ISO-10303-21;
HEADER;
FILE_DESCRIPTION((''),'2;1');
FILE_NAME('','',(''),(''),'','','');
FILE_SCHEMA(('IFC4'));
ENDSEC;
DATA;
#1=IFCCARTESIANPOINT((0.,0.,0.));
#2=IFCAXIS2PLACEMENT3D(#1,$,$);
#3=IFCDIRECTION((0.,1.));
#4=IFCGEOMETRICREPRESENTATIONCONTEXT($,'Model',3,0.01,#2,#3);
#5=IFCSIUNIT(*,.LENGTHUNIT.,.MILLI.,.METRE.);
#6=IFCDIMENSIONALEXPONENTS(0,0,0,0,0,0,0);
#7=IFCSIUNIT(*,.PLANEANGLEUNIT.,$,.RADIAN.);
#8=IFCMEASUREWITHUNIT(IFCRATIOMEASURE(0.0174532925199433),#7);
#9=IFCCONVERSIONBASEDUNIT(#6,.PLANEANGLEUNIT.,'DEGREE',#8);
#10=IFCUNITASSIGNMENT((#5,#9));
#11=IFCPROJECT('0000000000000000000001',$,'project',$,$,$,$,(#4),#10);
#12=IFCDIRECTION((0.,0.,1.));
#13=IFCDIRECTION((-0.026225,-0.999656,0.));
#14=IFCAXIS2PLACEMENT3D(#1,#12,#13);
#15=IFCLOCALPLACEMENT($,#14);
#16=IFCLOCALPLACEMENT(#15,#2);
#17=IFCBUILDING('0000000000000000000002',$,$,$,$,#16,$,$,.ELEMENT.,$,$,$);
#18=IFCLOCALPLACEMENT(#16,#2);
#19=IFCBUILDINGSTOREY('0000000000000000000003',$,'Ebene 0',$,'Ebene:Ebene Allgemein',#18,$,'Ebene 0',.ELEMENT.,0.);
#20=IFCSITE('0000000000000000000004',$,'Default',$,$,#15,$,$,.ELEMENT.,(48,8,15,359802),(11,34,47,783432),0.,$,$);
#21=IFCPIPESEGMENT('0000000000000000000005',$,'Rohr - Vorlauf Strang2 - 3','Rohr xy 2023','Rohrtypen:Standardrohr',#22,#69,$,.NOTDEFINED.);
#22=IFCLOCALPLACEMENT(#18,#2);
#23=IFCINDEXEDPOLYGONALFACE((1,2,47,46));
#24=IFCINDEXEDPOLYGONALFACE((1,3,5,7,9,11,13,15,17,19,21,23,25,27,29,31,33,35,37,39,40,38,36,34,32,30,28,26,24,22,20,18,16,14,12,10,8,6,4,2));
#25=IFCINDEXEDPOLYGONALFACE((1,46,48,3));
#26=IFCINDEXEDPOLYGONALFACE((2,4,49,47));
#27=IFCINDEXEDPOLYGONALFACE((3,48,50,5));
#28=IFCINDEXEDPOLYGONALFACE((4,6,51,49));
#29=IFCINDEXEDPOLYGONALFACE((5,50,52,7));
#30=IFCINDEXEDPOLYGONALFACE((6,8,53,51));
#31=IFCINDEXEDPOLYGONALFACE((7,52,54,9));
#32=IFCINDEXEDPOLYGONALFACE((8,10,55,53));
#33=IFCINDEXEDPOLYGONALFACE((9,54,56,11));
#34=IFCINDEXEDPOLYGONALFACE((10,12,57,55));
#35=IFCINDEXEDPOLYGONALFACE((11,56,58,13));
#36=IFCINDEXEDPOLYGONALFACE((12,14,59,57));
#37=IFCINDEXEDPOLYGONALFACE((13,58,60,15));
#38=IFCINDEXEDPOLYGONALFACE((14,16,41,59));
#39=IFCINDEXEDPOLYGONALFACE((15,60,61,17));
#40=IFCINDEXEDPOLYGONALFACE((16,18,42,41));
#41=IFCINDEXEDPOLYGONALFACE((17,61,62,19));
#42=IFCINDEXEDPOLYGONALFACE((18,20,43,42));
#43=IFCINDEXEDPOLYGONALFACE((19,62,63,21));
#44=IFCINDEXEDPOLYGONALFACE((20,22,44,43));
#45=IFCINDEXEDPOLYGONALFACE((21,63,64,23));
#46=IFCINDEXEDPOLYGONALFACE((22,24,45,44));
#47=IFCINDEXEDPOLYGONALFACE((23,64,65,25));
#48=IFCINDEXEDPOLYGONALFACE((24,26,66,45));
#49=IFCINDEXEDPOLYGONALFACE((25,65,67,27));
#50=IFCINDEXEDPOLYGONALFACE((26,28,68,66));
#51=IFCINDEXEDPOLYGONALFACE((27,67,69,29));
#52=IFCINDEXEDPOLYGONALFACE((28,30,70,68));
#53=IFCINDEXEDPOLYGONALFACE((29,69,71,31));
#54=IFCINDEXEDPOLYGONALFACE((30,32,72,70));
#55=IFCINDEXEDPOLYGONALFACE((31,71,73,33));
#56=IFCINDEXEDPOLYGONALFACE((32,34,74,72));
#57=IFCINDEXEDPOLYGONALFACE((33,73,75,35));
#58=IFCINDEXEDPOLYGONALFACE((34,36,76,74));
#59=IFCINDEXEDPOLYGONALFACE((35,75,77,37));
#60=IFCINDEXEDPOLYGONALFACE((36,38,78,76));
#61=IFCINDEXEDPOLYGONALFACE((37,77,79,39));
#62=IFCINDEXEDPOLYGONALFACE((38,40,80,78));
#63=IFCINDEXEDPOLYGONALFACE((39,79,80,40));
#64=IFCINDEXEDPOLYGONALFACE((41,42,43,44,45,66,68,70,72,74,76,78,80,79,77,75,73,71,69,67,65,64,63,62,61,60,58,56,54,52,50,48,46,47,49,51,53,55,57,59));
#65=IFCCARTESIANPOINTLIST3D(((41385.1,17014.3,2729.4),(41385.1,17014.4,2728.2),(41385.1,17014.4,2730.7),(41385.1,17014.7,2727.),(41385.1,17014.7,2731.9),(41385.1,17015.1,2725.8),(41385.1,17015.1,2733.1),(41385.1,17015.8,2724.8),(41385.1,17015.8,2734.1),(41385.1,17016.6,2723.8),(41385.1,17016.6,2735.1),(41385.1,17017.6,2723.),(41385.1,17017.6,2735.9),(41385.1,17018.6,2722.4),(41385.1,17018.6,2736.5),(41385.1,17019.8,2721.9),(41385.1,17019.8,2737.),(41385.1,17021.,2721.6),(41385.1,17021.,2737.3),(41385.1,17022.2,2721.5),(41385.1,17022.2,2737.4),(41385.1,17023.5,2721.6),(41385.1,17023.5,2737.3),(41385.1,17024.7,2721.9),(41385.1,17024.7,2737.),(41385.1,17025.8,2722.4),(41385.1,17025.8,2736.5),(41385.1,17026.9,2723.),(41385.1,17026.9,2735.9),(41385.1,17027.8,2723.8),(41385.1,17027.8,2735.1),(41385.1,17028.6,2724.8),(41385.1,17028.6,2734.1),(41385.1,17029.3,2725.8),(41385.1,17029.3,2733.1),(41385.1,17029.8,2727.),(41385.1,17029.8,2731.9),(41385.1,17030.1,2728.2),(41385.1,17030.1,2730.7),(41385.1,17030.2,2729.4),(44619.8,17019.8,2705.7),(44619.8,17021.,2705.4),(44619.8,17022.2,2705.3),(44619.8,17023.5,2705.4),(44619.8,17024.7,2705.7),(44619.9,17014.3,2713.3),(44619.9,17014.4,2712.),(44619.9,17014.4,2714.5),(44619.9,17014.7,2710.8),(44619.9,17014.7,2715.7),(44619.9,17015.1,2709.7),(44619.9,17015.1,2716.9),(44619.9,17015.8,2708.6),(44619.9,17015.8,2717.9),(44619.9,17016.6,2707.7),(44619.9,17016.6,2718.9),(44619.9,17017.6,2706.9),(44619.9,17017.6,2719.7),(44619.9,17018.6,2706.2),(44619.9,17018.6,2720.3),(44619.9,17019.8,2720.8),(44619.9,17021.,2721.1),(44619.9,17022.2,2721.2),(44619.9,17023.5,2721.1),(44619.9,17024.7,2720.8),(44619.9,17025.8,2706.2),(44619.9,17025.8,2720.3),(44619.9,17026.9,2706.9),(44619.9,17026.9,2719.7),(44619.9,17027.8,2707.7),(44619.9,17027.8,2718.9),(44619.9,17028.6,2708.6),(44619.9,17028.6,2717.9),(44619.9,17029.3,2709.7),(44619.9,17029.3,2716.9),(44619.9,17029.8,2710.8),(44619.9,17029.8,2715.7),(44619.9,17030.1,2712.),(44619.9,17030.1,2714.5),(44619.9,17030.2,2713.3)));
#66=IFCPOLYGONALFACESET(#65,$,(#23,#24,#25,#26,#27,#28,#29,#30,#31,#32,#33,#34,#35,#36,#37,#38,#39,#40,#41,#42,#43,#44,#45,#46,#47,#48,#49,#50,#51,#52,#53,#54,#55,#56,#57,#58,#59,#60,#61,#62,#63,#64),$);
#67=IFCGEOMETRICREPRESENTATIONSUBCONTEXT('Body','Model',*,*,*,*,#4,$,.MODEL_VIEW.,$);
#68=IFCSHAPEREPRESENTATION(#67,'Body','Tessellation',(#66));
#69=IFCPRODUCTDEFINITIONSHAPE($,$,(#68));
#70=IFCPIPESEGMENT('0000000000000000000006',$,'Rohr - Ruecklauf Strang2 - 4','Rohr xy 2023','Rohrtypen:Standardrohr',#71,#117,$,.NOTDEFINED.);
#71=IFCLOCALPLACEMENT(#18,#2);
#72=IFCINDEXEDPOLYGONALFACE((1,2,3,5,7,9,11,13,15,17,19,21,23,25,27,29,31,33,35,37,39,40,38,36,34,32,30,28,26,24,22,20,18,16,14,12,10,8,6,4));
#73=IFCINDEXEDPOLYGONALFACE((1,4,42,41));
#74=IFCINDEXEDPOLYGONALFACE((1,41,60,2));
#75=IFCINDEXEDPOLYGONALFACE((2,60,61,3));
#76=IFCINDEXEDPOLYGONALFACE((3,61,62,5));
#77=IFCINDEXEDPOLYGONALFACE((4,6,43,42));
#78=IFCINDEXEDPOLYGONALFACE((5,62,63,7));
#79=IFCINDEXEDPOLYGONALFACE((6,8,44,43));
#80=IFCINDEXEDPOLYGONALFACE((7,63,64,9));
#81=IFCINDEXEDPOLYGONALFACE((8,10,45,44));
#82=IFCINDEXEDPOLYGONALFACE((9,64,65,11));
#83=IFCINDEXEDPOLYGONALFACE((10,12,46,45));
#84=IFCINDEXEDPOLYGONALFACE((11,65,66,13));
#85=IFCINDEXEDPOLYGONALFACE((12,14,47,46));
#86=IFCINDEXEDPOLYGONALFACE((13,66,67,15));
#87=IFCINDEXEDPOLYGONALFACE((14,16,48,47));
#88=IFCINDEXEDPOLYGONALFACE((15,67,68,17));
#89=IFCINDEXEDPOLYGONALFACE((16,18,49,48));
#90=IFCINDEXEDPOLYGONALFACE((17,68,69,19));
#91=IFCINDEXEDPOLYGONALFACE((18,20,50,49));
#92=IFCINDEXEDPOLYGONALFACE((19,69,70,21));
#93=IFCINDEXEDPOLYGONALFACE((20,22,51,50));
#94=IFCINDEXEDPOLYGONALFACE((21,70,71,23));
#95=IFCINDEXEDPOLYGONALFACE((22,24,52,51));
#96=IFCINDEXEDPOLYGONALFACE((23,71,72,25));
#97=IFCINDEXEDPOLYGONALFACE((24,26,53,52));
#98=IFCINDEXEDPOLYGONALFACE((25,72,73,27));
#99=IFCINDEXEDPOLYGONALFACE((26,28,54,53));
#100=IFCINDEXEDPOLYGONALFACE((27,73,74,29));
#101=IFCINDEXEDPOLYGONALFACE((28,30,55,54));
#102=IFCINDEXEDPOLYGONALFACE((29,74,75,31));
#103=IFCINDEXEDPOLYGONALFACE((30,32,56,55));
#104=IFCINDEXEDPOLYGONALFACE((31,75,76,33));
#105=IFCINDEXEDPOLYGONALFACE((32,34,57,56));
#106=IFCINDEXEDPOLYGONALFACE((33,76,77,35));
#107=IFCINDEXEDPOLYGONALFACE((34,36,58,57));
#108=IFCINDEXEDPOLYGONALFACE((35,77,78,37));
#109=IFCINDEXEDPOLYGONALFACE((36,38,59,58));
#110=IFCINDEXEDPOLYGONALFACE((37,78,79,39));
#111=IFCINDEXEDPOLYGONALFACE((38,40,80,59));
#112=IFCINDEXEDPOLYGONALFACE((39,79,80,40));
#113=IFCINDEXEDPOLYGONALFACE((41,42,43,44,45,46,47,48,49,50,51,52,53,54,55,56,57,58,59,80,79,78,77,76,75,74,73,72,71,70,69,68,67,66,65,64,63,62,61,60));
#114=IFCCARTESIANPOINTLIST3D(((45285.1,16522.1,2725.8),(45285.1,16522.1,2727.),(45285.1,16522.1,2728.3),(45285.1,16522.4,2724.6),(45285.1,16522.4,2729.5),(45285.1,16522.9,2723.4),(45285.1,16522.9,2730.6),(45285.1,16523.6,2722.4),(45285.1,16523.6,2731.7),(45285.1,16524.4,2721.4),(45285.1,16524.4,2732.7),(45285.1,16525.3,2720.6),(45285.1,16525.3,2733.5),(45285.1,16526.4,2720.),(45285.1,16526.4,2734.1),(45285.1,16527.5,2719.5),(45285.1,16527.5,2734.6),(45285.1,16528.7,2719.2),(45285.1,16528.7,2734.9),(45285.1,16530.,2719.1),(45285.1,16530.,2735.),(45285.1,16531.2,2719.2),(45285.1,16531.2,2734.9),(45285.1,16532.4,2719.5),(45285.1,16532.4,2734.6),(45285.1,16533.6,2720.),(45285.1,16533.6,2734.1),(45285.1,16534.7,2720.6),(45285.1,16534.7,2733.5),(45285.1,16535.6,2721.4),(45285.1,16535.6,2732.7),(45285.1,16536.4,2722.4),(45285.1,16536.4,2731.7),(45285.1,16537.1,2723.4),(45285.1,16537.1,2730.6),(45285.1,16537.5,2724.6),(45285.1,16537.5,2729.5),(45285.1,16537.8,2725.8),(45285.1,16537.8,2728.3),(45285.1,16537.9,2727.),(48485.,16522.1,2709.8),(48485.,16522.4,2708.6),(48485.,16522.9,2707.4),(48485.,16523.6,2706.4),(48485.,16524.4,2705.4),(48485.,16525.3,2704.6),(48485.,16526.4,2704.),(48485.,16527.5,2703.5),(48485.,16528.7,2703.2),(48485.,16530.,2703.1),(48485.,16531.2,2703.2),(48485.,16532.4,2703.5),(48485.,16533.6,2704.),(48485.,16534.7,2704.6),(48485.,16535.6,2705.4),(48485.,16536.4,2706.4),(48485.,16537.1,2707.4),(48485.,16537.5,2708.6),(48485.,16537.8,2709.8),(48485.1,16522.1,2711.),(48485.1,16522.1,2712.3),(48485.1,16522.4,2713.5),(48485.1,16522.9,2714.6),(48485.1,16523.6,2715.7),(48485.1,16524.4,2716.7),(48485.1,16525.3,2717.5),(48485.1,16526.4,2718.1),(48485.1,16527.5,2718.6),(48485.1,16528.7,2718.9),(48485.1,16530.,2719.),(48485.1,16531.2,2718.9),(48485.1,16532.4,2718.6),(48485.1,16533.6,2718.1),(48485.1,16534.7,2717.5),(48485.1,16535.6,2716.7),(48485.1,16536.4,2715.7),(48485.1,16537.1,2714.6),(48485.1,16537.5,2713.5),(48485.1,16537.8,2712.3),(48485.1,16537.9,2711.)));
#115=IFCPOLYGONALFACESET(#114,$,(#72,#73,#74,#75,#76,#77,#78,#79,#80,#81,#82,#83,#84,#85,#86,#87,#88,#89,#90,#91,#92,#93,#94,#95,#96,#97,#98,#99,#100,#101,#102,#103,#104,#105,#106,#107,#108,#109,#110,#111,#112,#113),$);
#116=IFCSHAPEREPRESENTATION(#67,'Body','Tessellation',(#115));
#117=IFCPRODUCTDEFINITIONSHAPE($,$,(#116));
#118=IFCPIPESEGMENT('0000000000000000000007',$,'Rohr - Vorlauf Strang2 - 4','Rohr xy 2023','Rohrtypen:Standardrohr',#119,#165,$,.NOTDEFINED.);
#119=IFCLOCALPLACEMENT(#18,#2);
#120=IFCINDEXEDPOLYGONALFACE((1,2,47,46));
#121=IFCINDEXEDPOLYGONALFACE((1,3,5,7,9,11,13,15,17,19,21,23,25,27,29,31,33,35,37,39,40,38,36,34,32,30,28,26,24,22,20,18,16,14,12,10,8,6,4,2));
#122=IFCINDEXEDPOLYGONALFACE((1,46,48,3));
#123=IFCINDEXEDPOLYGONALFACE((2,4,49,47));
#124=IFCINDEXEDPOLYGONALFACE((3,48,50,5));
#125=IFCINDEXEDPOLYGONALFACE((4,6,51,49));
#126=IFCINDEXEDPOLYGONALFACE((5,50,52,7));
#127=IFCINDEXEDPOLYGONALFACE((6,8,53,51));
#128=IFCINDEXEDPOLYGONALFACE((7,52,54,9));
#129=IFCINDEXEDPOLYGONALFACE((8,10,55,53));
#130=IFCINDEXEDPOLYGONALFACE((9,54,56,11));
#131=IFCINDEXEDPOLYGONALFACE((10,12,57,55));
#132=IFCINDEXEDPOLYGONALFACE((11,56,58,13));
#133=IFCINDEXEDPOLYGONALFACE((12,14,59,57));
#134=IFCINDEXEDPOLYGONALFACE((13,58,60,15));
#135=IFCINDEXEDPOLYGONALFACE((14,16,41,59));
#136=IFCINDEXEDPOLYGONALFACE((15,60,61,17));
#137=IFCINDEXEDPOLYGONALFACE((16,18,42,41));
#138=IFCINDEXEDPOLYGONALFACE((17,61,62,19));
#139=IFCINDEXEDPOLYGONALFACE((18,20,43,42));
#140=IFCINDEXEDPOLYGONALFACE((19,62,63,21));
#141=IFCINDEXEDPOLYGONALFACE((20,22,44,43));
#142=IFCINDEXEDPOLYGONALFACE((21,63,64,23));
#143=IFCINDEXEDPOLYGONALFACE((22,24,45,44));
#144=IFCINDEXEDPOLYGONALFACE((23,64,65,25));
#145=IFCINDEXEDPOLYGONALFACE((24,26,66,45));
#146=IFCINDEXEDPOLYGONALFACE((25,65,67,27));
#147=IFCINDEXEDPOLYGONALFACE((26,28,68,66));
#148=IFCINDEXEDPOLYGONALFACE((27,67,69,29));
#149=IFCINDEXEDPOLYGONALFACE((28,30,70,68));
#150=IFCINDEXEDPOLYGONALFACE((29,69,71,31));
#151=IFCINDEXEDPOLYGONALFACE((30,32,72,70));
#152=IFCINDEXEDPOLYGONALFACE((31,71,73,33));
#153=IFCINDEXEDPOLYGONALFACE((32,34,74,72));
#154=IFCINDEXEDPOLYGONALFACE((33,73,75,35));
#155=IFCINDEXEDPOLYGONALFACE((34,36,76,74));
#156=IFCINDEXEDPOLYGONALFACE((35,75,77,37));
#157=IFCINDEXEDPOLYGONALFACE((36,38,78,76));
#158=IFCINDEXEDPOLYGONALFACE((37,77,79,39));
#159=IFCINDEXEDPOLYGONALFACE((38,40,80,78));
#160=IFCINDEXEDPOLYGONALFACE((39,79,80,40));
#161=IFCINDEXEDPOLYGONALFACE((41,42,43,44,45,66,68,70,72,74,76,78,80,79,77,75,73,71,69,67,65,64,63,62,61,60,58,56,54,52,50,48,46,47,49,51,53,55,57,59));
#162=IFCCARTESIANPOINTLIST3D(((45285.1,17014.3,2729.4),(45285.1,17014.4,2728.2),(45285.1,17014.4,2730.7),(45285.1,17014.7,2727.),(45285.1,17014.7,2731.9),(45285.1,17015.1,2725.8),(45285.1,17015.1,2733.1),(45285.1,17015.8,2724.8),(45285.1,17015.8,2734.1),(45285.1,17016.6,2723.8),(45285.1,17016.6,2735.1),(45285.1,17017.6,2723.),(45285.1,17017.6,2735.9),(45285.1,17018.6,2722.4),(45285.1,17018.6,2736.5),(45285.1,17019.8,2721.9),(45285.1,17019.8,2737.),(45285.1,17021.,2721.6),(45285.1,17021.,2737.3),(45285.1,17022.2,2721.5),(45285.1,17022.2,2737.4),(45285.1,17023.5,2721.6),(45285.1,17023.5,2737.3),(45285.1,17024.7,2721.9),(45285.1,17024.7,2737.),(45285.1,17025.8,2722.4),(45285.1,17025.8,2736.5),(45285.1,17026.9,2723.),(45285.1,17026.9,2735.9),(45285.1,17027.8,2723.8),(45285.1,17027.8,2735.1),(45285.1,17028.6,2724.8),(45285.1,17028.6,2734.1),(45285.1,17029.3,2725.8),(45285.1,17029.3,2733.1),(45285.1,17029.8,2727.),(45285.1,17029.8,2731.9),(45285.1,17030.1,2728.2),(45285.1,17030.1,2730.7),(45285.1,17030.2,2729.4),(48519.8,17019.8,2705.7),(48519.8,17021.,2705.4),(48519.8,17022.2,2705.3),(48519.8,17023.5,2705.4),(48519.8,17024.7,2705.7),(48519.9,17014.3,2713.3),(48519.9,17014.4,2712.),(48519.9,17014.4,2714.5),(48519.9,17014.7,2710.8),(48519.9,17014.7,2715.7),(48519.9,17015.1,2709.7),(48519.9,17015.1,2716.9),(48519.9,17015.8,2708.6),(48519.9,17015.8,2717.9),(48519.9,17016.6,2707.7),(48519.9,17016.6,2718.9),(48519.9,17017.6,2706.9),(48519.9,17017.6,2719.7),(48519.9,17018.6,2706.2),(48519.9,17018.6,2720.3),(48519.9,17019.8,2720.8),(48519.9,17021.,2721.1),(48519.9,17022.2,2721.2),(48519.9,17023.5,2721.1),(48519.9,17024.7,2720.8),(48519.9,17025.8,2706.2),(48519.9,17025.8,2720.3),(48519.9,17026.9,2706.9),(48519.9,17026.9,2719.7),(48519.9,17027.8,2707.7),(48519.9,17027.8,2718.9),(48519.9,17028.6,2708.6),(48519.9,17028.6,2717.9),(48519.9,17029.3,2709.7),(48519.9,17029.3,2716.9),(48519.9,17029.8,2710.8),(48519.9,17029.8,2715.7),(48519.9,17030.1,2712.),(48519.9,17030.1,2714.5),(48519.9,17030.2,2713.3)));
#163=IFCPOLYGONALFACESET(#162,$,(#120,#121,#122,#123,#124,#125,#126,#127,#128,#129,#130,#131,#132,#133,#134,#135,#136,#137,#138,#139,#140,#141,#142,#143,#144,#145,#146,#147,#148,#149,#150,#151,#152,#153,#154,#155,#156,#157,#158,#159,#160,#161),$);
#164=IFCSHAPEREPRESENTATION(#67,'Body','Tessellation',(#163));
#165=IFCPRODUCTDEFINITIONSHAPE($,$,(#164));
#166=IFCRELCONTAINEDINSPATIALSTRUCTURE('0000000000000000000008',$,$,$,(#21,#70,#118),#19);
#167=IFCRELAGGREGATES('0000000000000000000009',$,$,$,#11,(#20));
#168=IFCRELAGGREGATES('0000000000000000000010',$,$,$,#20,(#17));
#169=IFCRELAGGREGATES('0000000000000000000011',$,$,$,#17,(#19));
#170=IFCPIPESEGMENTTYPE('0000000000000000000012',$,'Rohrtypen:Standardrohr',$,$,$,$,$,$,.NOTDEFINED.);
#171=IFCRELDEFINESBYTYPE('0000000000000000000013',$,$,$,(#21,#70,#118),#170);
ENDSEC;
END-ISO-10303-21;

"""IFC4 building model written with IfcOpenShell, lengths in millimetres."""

from ifc_helpers import new_model, entity, si_unit, converted_unit, direction, frame, origin, place, context, subcontext, project, spatial, indexed_curve, outline, extrude, type_object, element, save


model = new_model("IFC4")

# Units and contexts
model_context = context("Model", 3, precision=0.01, world=origin(), true_north=direction((0.0, 1.0)))
body_context = subcontext(model_context, "Body", "Model", "MODEL_VIEW")
ifc_project = project(units=[si_unit("LENGTHUNIT", "METRE", prefix="MILLI"), converted_unit("PLANEANGLEUNIT", "DEGREE", entity("IfcRatioMeasure", 0.0174532925199433), si_unit("PLANEANGLEUNIT", "RADIAN"), dimensions=[0, 0, 0, 0, 0, 0, 0])], contexts=[model_context])

# Site, building, storey
site_placement = place(None, frame((0.0, 0.0, 0.0), z_axis=(0.0, 0.0, 1.0), x_axis=(-0.026225, -0.999656, 0.0)))
site = spatial("IfcSite", under=ifc_project, at=site_placement, Name="Default", CompositionType="ELEMENT", RefLatitude=(48, 8, 15, 359802), RefLongitude=(11, 34, 47, 783432), RefElevation=0.0)
building_placement = place(site_placement, origin())
building = spatial("IfcBuilding", under=site, at=building_placement, CompositionType="ELEMENT")
storey_placement = place(building_placement, origin())
storey = spatial("IfcBuildingStorey", under=building, at=storey_placement, Name="Ebene 0", ObjectType="Ebene:Ebene Allgemein", LongName="Ebene 0", CompositionType="ELEMENT", Elevation=0.0)

# Pipe segments
pipe_segment_type = type_object("IfcPipeSegmentType", Name="Rohrtypen:Standardrohr", PredefinedType="NOTDEFINED")
pipe_segment_1_placement = place(storey_placement, origin())
element("IfcPipeSegment", 1, at=pipe_segment_1_placement, inside=storey, type_object=pipe_segment_type, Name="Rohr - Vorlauf Strang2 - 3", Description="Rohr xy 2023", ObjectType="Rohrtypen:Standardrohr", PredefinedType="NOTDEFINED", context=body_context, shape_type="SweptSolid", body=[
    extrude(outline(indexed_curve([(7.9, 0.0), (7.8, 1.2), (7.6, 2.5), (7.1, 3.6), (6.4, 4.7), (5.6, 5.6), (4.7, 6.4), (3.6, 7.1), (2.5, 7.6), (1.2, 7.8), (0.0, 7.9), (-1.2, 7.8), (-2.5, 7.6), (-3.6, 7.1), (-4.7, 6.4), (-5.6, 5.6), (-6.4, 4.7), (-7.1, 3.6), (-7.6, 2.5), (-7.8, 1.2), (-7.9, 0.0), (-7.8, -1.2), (-7.6, -2.5), (-7.1, -3.6), (-6.4, -4.7), (-5.6, -5.6), (-4.7, -6.4), (-3.6, -7.1), (-2.5, -7.6), (-1.2, -7.8), (0.0, -7.9), (1.2, -7.8), (2.5, -7.6), (3.6, -7.1), (4.7, -6.4), (5.6, -5.6), (6.4, -4.7), (7.1, -3.6), (7.6, -2.5), (7.8, -1.2), (7.9, 0.0)], self_intersect=False)), frame((44619.9, 17022.2, 2713.3), z_axis=(-0.999988, 0.0, 0.005), x_axis=(0.0, 1.0, 0.0)), (0.0, 0.0, 1.0), 3234.8),
])
pipe_segment_2_placement = place(storey_placement, origin())
element("IfcPipeSegment", 2, at=pipe_segment_2_placement, inside=storey, type_object=pipe_segment_type, Name="Rohr - Ruecklauf Strang2 - 4", Description="Rohr xy 2023", ObjectType="Rohrtypen:Standardrohr", PredefinedType="NOTDEFINED", context=body_context, shape_type="SweptSolid", body=[
    extrude(outline(indexed_curve([(7.9, 0.0), (7.8, 1.2), (7.6, 2.5), (7.1, 3.6), (6.4, 4.7), (5.6, 5.6), (4.7, 6.4), (3.6, 7.1), (2.5, 7.6), (1.2, 7.8), (0.0, 7.9), (-1.2, 7.8), (-2.5, 7.6), (-3.6, 7.1), (-4.7, 6.4), (-5.6, 5.6), (-6.4, 4.7), (-7.1, 3.6), (-7.6, 2.5), (-7.8, 1.2), (-7.9, 0.0), (-7.8, -1.2), (-7.6, -2.5), (-7.1, -3.6), (-6.4, -4.7), (-5.6, -5.6), (-4.7, -6.4), (-3.6, -7.1), (-2.5, -7.6), (-1.2, -7.8), (0.0, -7.9), (1.2, -7.8), (2.5, -7.6), (3.6, -7.1), (4.7, -6.4), (5.6, -5.6), (6.4, -4.7), (7.1, -3.6), (7.6, -2.5), (7.8, -1.2), (7.9, 0.0)], self_intersect=False)), frame((48485.1, 16530.0, 2711.0), z_axis=(-0.999988, 0.0, 0.005), x_axis=(0.0, 1.0, 0.0)), (0.0, 0.0, 1.0), 3200.0),
])
pipe_segment_3_placement = place(storey_placement, origin())
element("IfcPipeSegment", 3, at=pipe_segment_3_placement, inside=storey, type_object=pipe_segment_type, Name="Rohr - Vorlauf Strang2 - 4", Description="Rohr xy 2023", ObjectType="Rohrtypen:Standardrohr", PredefinedType="NOTDEFINED", context=body_context, shape_type="SweptSolid", body=[
    extrude(outline(indexed_curve([(7.9, 0.0), (7.8, 1.2), (7.6, 2.5), (7.1, 3.6), (6.4, 4.7), (5.6, 5.6), (4.7, 6.4), (3.6, 7.1), (2.5, 7.6), (1.2, 7.8), (0.0, 7.9), (-1.2, 7.8), (-2.5, 7.6), (-3.6, 7.1), (-4.7, 6.4), (-5.6, 5.6), (-6.4, 4.7), (-7.1, 3.6), (-7.6, 2.5), (-7.8, 1.2), (-7.9, 0.0), (-7.8, -1.2), (-7.6, -2.5), (-7.1, -3.6), (-6.4, -4.7), (-5.6, -5.6), (-4.7, -6.4), (-3.6, -7.1), (-2.5, -7.6), (-1.2, -7.8), (0.0, -7.9), (1.2, -7.8), (2.5, -7.6), (3.6, -7.1), (4.7, -6.4), (5.6, -5.6), (6.4, -4.7), (7.1, -3.6), (7.6, -2.5), (7.8, -1.2), (7.9, 0.0)], self_intersect=False)), frame((48519.9, 17022.2, 2713.3), z_axis=(-0.999988, 0.0, 0.005), x_axis=(0.0, 1.0, 0.0)), (0.0, 0.0, 1.0), 3234.8),
])

save(model, "model.ifc")
